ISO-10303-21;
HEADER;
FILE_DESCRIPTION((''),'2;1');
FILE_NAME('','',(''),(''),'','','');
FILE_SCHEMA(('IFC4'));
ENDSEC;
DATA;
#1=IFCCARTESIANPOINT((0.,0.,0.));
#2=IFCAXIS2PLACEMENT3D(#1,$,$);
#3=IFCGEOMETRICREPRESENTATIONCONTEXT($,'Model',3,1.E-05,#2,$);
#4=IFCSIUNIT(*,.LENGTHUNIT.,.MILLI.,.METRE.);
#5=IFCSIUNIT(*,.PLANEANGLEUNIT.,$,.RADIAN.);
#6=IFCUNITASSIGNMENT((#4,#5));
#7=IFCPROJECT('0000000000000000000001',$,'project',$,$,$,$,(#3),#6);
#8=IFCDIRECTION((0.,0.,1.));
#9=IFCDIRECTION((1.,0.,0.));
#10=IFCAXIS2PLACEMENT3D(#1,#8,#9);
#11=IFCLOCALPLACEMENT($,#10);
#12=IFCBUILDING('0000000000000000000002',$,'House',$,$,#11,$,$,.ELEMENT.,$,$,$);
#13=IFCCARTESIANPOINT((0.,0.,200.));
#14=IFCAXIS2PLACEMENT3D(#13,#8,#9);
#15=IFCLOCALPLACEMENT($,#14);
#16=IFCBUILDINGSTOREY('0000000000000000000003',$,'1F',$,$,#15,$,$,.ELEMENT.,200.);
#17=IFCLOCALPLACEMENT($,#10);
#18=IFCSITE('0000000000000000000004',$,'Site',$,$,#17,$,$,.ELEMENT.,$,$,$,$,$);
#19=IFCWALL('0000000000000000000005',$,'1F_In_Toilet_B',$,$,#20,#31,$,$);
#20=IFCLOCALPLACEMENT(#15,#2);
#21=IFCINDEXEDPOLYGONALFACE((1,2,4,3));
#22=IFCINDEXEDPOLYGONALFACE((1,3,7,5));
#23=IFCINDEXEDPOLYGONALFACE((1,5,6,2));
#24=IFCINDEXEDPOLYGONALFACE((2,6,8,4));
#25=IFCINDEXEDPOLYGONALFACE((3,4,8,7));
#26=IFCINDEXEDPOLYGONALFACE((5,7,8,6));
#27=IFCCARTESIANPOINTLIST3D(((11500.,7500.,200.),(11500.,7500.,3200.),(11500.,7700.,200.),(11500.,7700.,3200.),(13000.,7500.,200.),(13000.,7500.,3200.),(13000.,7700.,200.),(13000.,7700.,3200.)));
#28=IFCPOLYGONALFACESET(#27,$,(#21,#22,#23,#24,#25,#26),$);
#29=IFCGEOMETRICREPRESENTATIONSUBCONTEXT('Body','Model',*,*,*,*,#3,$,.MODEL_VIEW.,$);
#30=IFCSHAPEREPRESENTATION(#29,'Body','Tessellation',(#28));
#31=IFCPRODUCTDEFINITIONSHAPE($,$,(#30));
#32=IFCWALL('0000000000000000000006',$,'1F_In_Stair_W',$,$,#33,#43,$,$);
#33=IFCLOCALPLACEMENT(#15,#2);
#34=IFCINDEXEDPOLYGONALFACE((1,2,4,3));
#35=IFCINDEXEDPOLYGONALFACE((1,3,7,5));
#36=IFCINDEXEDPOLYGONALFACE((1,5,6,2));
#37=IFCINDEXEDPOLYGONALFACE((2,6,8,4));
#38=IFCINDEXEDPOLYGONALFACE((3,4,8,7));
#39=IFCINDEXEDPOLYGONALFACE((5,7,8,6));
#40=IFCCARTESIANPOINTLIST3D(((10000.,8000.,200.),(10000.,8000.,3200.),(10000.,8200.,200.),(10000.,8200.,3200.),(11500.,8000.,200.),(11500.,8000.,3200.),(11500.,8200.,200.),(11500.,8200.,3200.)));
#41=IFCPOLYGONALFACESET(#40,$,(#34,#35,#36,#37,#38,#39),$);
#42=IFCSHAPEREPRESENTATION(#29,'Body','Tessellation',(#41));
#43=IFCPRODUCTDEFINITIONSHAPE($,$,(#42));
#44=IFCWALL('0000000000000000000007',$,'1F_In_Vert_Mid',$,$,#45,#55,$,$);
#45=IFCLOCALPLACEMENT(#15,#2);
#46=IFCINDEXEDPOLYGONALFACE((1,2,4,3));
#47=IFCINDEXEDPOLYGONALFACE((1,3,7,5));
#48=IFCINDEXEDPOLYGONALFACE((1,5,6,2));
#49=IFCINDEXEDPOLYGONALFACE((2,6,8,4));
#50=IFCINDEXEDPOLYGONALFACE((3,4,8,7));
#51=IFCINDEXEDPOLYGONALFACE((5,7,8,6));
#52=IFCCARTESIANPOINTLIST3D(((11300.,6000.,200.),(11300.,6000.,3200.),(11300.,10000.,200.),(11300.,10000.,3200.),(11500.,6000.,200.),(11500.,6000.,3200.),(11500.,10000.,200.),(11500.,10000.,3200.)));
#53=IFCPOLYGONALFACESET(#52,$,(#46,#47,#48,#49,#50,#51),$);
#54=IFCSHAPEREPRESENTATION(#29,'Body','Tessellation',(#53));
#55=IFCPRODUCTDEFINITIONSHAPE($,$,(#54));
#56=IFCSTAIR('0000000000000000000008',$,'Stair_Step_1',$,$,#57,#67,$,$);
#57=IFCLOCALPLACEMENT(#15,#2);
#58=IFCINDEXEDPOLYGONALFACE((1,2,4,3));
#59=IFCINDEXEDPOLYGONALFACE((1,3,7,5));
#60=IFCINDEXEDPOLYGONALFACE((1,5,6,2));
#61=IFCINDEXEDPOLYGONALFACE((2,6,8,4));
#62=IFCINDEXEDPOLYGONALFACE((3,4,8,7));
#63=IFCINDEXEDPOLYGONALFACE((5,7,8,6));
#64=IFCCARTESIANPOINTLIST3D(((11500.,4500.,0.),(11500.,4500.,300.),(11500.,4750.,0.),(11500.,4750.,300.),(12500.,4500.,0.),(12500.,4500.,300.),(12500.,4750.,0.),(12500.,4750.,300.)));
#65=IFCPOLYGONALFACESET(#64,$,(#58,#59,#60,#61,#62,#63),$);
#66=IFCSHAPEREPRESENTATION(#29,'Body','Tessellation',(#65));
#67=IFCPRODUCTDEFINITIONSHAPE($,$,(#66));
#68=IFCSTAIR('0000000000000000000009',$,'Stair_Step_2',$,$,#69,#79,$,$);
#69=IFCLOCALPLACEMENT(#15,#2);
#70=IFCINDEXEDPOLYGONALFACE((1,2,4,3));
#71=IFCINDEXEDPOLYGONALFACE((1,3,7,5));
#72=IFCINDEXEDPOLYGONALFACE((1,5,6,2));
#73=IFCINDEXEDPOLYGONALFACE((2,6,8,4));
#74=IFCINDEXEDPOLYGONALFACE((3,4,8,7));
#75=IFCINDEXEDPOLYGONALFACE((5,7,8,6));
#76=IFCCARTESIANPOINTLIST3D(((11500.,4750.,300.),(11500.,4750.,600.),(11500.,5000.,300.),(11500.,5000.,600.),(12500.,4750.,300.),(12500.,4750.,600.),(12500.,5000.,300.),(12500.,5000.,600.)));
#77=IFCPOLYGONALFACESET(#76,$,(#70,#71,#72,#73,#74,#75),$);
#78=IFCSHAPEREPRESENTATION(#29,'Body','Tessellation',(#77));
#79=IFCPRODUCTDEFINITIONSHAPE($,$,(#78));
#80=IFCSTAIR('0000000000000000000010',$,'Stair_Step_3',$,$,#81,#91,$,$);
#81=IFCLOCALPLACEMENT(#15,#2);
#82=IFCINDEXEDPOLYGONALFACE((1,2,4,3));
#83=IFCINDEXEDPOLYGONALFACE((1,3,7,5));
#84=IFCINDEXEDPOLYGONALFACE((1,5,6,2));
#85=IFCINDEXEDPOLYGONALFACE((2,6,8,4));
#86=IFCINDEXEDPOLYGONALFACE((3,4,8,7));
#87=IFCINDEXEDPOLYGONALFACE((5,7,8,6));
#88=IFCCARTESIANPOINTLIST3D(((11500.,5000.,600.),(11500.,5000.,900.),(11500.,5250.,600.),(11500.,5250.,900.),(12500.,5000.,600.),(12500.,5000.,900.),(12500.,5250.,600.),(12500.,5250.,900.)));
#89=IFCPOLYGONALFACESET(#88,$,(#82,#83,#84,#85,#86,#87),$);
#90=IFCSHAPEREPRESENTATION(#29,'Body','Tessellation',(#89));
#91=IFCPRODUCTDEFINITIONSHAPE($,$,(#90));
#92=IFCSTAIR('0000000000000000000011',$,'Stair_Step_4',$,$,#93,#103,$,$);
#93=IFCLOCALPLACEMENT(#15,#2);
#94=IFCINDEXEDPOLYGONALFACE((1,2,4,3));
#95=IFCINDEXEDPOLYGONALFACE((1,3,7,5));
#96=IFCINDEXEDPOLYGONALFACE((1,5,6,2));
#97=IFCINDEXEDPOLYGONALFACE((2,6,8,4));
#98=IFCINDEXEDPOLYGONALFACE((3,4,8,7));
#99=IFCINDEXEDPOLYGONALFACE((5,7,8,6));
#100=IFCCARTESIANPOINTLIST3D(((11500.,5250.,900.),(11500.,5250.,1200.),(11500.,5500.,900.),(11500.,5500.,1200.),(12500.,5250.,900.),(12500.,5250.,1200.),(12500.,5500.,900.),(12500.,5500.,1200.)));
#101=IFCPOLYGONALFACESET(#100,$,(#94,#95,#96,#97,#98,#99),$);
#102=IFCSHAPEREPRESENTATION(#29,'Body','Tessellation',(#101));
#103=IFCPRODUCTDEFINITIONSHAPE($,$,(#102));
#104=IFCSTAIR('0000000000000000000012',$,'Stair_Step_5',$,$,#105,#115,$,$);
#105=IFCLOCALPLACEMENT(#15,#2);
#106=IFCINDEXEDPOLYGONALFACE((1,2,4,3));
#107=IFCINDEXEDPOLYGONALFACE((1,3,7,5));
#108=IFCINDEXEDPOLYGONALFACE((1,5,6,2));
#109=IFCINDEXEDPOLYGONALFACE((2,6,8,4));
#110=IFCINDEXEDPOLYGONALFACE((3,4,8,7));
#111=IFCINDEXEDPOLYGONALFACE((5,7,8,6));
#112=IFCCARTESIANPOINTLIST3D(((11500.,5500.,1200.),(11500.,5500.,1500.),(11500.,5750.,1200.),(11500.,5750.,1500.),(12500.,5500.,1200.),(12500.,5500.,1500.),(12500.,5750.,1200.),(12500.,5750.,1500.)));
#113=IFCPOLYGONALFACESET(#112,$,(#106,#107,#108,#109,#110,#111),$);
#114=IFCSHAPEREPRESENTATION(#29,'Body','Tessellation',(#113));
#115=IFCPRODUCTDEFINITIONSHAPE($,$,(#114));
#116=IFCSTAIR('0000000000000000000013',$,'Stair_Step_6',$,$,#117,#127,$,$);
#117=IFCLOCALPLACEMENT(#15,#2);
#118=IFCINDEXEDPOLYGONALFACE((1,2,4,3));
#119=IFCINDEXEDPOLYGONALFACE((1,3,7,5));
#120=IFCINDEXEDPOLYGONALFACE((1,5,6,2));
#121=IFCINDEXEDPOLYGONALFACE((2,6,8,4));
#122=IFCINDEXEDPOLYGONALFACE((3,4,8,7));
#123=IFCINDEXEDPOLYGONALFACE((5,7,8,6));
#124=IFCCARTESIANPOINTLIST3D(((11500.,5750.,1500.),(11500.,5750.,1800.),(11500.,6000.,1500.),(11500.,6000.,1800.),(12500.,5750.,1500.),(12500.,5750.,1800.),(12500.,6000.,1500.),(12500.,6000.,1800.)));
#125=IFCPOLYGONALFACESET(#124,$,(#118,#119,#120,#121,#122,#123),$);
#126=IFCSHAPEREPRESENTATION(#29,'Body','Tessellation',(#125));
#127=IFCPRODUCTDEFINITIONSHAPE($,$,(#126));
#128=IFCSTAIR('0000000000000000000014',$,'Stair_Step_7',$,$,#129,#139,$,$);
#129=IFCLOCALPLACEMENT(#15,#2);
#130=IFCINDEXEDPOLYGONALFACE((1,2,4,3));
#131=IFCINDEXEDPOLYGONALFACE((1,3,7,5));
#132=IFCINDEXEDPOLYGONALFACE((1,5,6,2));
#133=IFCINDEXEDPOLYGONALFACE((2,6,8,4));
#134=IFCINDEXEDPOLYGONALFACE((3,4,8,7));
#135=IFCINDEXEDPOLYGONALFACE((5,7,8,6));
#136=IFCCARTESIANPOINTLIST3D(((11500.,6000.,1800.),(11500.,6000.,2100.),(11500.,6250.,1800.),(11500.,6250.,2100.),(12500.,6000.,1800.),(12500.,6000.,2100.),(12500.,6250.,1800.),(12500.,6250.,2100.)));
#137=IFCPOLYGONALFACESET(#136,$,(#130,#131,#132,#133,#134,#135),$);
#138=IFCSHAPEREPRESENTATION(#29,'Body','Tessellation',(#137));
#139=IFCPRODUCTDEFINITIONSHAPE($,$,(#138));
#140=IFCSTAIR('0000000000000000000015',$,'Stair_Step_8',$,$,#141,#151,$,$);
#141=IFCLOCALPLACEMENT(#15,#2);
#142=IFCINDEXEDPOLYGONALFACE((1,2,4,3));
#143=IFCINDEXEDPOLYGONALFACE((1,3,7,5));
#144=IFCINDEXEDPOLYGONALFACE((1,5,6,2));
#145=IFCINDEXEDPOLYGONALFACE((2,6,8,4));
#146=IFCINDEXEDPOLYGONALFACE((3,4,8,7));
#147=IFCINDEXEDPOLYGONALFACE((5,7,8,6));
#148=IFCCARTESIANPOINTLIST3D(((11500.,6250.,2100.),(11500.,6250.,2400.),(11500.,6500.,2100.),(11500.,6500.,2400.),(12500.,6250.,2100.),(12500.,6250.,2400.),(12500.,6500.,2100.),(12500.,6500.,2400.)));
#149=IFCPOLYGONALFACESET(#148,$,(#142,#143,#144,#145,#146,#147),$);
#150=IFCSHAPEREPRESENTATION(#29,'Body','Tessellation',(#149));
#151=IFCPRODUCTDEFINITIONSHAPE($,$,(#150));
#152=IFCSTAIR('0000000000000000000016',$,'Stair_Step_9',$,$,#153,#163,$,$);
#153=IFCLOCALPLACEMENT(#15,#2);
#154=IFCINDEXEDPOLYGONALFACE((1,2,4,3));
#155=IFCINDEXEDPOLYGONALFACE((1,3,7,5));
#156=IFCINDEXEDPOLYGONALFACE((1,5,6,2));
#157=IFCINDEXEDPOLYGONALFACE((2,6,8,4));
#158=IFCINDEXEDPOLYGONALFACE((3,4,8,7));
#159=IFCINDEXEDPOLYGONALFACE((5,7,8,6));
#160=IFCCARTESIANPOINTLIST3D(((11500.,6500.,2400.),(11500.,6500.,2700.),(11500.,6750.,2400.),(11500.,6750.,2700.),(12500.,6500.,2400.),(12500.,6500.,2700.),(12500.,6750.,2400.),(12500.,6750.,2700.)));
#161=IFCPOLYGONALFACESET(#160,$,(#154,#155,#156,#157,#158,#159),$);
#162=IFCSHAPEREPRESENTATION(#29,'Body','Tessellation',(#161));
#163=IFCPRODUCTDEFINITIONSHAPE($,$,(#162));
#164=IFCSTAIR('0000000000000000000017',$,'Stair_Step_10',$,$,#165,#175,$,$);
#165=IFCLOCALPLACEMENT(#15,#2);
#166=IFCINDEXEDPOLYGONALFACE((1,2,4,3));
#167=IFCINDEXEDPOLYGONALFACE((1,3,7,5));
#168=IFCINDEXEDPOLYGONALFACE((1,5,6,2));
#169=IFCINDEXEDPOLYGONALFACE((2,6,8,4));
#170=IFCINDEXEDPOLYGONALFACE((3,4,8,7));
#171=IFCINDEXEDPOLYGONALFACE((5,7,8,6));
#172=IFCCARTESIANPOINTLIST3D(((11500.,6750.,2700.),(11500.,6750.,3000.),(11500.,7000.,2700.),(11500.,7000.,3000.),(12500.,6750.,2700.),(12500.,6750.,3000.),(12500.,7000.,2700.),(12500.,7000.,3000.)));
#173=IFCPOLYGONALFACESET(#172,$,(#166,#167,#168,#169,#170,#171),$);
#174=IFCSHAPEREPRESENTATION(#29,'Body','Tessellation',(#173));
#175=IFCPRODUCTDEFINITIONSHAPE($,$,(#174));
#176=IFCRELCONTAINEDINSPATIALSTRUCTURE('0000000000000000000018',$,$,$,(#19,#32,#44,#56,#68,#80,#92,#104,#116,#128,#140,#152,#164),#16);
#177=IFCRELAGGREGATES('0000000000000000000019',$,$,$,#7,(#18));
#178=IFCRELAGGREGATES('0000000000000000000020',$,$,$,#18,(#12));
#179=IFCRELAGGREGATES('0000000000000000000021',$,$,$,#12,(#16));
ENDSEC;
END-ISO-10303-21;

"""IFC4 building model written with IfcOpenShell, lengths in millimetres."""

from ifc_helpers import new_model, si_unit, frame, origin, origin_with_axes, place, context, subcontext, project, spatial, rectangle, extrude, element, save


model = new_model("IFC4")

# Units and contexts
model_context = context("Model", 3, precision=1e-05, world=origin())
body_context = subcontext(model_context, "Body", "Model", "MODEL_VIEW")
ifc_project = project(units=[si_unit("LENGTHUNIT", "METRE", prefix="MILLI"), si_unit("PLANEANGLEUNIT", "RADIAN")], contexts=[model_context])

# Site, building, storey
site_placement = place(None, origin_with_axes())
site = spatial("IfcSite", under=ifc_project, at=site_placement, Name="Site", CompositionType="ELEMENT")
building_placement = place(None, origin_with_axes())
building = spatial("IfcBuilding", under=site, at=building_placement, Name="House", CompositionType="ELEMENT")
storey_placement = place(None, frame((0.0, 0.0, 200.0), z_axis=(0.0, 0.0, 1.0), x_axis=(1.0, 0.0, 0.0)))
storey = spatial("IfcBuildingStorey", under=building, at=storey_placement, Name="1F", CompositionType="ELEMENT", Elevation=200.0)

# Walls
for number, where, z_axis, x_axis, name in (
    (1, (11500.0, 7500.0, 400.0), (0.0, 0.0, 1.0), (1.0, 0.0, 0.0), "1F_In_Toilet_B"),
    (2, (10000.0, 8000.0, 400.0), (0.0, 0.0, 1.0), (1.0, 0.0, 0.0), "1F_In_Stair_W"),
):
    element("IfcWall", number, at=place(None, frame(where, z_axis=z_axis, x_axis=x_axis)), inside=storey, Name=name, context=body_context, shape_type="SweptSolid", body=[
        extrude(rectangle(XDim=1500.0, YDim=200.0), frame((750.0, 100.0, 0.0)), (0.0, 0.0, 1.0), 3000.0),
    ])
wall_1_placement = place(None, frame((11300.0, 6000.0, 400.0), z_axis=(0.0, 0.0, 1.0), x_axis=(1.0, 0.0, 0.0)))
element("IfcWall", 3, at=wall_1_placement, inside=storey, Name="1F_In_Vert_Mid", context=body_context, shape_type="SweptSolid", body=[
    extrude(rectangle(XDim=200.0, YDim=4000.0), frame((100.0, 2000.0, 0.0)), (0.0, 0.0, 1.0), 3000.0),
])

# Stairs
for number, where, z_axis, x_axis, name in (
    (4, (11500.0, 4500.0, 200.0), (0.0, 0.0, 1.0), (1.0, 0.0, 0.0), "Stair_Step_1"),
    (5, (11500.0, 4750.0, 500.0), (0.0, 0.0, 1.0), (1.0, 0.0, 0.0), "Stair_Step_2"),
    (6, (11500.0, 5000.0, 800.0), (0.0, 0.0, 1.0), (1.0, 0.0, 0.0), "Stair_Step_3"),
    (7, (11500.0, 5250.0, 1100.0), (0.0, 0.0, 1.0), (1.0, 0.0, 0.0), "Stair_Step_4"),
    (8, (11500.0, 5500.0, 1400.0), (0.0, 0.0, 1.0), (1.0, 0.0, 0.0), "Stair_Step_5"),
    (9, (11500.0, 5750.0, 1700.0), (0.0, 0.0, 1.0), (1.0, 0.0, 0.0), "Stair_Step_6"),
    (10, (11500.0, 6000.0, 2000.0), (0.0, 0.0, 1.0), (1.0, 0.0, 0.0), "Stair_Step_7"),
    (11, (11500.0, 6250.0, 2300.0), (0.0, 0.0, 1.0), (1.0, 0.0, 0.0), "Stair_Step_8"),
    (12, (11500.0, 6500.0, 2600.0), (0.0, 0.0, 1.0), (1.0, 0.0, 0.0), "Stair_Step_9"),
    (13, (11500.0, 6750.0, 2900.0), (0.0, 0.0, 1.0), (1.0, 0.0, 0.0), "Stair_Step_10"),
):
    element("IfcStair", number, at=place(None, frame(where, z_axis=z_axis, x_axis=x_axis)), inside=storey, Name=name, context=body_context, shape_type="SweptSolid", body=[
        extrude(rectangle(XDim=1000.0, YDim=250.0), frame((500.0, 125.0, 0.0)), (0.0, 0.0, 1.0), 300.0),
    ])

save(model, "model.ifc")
